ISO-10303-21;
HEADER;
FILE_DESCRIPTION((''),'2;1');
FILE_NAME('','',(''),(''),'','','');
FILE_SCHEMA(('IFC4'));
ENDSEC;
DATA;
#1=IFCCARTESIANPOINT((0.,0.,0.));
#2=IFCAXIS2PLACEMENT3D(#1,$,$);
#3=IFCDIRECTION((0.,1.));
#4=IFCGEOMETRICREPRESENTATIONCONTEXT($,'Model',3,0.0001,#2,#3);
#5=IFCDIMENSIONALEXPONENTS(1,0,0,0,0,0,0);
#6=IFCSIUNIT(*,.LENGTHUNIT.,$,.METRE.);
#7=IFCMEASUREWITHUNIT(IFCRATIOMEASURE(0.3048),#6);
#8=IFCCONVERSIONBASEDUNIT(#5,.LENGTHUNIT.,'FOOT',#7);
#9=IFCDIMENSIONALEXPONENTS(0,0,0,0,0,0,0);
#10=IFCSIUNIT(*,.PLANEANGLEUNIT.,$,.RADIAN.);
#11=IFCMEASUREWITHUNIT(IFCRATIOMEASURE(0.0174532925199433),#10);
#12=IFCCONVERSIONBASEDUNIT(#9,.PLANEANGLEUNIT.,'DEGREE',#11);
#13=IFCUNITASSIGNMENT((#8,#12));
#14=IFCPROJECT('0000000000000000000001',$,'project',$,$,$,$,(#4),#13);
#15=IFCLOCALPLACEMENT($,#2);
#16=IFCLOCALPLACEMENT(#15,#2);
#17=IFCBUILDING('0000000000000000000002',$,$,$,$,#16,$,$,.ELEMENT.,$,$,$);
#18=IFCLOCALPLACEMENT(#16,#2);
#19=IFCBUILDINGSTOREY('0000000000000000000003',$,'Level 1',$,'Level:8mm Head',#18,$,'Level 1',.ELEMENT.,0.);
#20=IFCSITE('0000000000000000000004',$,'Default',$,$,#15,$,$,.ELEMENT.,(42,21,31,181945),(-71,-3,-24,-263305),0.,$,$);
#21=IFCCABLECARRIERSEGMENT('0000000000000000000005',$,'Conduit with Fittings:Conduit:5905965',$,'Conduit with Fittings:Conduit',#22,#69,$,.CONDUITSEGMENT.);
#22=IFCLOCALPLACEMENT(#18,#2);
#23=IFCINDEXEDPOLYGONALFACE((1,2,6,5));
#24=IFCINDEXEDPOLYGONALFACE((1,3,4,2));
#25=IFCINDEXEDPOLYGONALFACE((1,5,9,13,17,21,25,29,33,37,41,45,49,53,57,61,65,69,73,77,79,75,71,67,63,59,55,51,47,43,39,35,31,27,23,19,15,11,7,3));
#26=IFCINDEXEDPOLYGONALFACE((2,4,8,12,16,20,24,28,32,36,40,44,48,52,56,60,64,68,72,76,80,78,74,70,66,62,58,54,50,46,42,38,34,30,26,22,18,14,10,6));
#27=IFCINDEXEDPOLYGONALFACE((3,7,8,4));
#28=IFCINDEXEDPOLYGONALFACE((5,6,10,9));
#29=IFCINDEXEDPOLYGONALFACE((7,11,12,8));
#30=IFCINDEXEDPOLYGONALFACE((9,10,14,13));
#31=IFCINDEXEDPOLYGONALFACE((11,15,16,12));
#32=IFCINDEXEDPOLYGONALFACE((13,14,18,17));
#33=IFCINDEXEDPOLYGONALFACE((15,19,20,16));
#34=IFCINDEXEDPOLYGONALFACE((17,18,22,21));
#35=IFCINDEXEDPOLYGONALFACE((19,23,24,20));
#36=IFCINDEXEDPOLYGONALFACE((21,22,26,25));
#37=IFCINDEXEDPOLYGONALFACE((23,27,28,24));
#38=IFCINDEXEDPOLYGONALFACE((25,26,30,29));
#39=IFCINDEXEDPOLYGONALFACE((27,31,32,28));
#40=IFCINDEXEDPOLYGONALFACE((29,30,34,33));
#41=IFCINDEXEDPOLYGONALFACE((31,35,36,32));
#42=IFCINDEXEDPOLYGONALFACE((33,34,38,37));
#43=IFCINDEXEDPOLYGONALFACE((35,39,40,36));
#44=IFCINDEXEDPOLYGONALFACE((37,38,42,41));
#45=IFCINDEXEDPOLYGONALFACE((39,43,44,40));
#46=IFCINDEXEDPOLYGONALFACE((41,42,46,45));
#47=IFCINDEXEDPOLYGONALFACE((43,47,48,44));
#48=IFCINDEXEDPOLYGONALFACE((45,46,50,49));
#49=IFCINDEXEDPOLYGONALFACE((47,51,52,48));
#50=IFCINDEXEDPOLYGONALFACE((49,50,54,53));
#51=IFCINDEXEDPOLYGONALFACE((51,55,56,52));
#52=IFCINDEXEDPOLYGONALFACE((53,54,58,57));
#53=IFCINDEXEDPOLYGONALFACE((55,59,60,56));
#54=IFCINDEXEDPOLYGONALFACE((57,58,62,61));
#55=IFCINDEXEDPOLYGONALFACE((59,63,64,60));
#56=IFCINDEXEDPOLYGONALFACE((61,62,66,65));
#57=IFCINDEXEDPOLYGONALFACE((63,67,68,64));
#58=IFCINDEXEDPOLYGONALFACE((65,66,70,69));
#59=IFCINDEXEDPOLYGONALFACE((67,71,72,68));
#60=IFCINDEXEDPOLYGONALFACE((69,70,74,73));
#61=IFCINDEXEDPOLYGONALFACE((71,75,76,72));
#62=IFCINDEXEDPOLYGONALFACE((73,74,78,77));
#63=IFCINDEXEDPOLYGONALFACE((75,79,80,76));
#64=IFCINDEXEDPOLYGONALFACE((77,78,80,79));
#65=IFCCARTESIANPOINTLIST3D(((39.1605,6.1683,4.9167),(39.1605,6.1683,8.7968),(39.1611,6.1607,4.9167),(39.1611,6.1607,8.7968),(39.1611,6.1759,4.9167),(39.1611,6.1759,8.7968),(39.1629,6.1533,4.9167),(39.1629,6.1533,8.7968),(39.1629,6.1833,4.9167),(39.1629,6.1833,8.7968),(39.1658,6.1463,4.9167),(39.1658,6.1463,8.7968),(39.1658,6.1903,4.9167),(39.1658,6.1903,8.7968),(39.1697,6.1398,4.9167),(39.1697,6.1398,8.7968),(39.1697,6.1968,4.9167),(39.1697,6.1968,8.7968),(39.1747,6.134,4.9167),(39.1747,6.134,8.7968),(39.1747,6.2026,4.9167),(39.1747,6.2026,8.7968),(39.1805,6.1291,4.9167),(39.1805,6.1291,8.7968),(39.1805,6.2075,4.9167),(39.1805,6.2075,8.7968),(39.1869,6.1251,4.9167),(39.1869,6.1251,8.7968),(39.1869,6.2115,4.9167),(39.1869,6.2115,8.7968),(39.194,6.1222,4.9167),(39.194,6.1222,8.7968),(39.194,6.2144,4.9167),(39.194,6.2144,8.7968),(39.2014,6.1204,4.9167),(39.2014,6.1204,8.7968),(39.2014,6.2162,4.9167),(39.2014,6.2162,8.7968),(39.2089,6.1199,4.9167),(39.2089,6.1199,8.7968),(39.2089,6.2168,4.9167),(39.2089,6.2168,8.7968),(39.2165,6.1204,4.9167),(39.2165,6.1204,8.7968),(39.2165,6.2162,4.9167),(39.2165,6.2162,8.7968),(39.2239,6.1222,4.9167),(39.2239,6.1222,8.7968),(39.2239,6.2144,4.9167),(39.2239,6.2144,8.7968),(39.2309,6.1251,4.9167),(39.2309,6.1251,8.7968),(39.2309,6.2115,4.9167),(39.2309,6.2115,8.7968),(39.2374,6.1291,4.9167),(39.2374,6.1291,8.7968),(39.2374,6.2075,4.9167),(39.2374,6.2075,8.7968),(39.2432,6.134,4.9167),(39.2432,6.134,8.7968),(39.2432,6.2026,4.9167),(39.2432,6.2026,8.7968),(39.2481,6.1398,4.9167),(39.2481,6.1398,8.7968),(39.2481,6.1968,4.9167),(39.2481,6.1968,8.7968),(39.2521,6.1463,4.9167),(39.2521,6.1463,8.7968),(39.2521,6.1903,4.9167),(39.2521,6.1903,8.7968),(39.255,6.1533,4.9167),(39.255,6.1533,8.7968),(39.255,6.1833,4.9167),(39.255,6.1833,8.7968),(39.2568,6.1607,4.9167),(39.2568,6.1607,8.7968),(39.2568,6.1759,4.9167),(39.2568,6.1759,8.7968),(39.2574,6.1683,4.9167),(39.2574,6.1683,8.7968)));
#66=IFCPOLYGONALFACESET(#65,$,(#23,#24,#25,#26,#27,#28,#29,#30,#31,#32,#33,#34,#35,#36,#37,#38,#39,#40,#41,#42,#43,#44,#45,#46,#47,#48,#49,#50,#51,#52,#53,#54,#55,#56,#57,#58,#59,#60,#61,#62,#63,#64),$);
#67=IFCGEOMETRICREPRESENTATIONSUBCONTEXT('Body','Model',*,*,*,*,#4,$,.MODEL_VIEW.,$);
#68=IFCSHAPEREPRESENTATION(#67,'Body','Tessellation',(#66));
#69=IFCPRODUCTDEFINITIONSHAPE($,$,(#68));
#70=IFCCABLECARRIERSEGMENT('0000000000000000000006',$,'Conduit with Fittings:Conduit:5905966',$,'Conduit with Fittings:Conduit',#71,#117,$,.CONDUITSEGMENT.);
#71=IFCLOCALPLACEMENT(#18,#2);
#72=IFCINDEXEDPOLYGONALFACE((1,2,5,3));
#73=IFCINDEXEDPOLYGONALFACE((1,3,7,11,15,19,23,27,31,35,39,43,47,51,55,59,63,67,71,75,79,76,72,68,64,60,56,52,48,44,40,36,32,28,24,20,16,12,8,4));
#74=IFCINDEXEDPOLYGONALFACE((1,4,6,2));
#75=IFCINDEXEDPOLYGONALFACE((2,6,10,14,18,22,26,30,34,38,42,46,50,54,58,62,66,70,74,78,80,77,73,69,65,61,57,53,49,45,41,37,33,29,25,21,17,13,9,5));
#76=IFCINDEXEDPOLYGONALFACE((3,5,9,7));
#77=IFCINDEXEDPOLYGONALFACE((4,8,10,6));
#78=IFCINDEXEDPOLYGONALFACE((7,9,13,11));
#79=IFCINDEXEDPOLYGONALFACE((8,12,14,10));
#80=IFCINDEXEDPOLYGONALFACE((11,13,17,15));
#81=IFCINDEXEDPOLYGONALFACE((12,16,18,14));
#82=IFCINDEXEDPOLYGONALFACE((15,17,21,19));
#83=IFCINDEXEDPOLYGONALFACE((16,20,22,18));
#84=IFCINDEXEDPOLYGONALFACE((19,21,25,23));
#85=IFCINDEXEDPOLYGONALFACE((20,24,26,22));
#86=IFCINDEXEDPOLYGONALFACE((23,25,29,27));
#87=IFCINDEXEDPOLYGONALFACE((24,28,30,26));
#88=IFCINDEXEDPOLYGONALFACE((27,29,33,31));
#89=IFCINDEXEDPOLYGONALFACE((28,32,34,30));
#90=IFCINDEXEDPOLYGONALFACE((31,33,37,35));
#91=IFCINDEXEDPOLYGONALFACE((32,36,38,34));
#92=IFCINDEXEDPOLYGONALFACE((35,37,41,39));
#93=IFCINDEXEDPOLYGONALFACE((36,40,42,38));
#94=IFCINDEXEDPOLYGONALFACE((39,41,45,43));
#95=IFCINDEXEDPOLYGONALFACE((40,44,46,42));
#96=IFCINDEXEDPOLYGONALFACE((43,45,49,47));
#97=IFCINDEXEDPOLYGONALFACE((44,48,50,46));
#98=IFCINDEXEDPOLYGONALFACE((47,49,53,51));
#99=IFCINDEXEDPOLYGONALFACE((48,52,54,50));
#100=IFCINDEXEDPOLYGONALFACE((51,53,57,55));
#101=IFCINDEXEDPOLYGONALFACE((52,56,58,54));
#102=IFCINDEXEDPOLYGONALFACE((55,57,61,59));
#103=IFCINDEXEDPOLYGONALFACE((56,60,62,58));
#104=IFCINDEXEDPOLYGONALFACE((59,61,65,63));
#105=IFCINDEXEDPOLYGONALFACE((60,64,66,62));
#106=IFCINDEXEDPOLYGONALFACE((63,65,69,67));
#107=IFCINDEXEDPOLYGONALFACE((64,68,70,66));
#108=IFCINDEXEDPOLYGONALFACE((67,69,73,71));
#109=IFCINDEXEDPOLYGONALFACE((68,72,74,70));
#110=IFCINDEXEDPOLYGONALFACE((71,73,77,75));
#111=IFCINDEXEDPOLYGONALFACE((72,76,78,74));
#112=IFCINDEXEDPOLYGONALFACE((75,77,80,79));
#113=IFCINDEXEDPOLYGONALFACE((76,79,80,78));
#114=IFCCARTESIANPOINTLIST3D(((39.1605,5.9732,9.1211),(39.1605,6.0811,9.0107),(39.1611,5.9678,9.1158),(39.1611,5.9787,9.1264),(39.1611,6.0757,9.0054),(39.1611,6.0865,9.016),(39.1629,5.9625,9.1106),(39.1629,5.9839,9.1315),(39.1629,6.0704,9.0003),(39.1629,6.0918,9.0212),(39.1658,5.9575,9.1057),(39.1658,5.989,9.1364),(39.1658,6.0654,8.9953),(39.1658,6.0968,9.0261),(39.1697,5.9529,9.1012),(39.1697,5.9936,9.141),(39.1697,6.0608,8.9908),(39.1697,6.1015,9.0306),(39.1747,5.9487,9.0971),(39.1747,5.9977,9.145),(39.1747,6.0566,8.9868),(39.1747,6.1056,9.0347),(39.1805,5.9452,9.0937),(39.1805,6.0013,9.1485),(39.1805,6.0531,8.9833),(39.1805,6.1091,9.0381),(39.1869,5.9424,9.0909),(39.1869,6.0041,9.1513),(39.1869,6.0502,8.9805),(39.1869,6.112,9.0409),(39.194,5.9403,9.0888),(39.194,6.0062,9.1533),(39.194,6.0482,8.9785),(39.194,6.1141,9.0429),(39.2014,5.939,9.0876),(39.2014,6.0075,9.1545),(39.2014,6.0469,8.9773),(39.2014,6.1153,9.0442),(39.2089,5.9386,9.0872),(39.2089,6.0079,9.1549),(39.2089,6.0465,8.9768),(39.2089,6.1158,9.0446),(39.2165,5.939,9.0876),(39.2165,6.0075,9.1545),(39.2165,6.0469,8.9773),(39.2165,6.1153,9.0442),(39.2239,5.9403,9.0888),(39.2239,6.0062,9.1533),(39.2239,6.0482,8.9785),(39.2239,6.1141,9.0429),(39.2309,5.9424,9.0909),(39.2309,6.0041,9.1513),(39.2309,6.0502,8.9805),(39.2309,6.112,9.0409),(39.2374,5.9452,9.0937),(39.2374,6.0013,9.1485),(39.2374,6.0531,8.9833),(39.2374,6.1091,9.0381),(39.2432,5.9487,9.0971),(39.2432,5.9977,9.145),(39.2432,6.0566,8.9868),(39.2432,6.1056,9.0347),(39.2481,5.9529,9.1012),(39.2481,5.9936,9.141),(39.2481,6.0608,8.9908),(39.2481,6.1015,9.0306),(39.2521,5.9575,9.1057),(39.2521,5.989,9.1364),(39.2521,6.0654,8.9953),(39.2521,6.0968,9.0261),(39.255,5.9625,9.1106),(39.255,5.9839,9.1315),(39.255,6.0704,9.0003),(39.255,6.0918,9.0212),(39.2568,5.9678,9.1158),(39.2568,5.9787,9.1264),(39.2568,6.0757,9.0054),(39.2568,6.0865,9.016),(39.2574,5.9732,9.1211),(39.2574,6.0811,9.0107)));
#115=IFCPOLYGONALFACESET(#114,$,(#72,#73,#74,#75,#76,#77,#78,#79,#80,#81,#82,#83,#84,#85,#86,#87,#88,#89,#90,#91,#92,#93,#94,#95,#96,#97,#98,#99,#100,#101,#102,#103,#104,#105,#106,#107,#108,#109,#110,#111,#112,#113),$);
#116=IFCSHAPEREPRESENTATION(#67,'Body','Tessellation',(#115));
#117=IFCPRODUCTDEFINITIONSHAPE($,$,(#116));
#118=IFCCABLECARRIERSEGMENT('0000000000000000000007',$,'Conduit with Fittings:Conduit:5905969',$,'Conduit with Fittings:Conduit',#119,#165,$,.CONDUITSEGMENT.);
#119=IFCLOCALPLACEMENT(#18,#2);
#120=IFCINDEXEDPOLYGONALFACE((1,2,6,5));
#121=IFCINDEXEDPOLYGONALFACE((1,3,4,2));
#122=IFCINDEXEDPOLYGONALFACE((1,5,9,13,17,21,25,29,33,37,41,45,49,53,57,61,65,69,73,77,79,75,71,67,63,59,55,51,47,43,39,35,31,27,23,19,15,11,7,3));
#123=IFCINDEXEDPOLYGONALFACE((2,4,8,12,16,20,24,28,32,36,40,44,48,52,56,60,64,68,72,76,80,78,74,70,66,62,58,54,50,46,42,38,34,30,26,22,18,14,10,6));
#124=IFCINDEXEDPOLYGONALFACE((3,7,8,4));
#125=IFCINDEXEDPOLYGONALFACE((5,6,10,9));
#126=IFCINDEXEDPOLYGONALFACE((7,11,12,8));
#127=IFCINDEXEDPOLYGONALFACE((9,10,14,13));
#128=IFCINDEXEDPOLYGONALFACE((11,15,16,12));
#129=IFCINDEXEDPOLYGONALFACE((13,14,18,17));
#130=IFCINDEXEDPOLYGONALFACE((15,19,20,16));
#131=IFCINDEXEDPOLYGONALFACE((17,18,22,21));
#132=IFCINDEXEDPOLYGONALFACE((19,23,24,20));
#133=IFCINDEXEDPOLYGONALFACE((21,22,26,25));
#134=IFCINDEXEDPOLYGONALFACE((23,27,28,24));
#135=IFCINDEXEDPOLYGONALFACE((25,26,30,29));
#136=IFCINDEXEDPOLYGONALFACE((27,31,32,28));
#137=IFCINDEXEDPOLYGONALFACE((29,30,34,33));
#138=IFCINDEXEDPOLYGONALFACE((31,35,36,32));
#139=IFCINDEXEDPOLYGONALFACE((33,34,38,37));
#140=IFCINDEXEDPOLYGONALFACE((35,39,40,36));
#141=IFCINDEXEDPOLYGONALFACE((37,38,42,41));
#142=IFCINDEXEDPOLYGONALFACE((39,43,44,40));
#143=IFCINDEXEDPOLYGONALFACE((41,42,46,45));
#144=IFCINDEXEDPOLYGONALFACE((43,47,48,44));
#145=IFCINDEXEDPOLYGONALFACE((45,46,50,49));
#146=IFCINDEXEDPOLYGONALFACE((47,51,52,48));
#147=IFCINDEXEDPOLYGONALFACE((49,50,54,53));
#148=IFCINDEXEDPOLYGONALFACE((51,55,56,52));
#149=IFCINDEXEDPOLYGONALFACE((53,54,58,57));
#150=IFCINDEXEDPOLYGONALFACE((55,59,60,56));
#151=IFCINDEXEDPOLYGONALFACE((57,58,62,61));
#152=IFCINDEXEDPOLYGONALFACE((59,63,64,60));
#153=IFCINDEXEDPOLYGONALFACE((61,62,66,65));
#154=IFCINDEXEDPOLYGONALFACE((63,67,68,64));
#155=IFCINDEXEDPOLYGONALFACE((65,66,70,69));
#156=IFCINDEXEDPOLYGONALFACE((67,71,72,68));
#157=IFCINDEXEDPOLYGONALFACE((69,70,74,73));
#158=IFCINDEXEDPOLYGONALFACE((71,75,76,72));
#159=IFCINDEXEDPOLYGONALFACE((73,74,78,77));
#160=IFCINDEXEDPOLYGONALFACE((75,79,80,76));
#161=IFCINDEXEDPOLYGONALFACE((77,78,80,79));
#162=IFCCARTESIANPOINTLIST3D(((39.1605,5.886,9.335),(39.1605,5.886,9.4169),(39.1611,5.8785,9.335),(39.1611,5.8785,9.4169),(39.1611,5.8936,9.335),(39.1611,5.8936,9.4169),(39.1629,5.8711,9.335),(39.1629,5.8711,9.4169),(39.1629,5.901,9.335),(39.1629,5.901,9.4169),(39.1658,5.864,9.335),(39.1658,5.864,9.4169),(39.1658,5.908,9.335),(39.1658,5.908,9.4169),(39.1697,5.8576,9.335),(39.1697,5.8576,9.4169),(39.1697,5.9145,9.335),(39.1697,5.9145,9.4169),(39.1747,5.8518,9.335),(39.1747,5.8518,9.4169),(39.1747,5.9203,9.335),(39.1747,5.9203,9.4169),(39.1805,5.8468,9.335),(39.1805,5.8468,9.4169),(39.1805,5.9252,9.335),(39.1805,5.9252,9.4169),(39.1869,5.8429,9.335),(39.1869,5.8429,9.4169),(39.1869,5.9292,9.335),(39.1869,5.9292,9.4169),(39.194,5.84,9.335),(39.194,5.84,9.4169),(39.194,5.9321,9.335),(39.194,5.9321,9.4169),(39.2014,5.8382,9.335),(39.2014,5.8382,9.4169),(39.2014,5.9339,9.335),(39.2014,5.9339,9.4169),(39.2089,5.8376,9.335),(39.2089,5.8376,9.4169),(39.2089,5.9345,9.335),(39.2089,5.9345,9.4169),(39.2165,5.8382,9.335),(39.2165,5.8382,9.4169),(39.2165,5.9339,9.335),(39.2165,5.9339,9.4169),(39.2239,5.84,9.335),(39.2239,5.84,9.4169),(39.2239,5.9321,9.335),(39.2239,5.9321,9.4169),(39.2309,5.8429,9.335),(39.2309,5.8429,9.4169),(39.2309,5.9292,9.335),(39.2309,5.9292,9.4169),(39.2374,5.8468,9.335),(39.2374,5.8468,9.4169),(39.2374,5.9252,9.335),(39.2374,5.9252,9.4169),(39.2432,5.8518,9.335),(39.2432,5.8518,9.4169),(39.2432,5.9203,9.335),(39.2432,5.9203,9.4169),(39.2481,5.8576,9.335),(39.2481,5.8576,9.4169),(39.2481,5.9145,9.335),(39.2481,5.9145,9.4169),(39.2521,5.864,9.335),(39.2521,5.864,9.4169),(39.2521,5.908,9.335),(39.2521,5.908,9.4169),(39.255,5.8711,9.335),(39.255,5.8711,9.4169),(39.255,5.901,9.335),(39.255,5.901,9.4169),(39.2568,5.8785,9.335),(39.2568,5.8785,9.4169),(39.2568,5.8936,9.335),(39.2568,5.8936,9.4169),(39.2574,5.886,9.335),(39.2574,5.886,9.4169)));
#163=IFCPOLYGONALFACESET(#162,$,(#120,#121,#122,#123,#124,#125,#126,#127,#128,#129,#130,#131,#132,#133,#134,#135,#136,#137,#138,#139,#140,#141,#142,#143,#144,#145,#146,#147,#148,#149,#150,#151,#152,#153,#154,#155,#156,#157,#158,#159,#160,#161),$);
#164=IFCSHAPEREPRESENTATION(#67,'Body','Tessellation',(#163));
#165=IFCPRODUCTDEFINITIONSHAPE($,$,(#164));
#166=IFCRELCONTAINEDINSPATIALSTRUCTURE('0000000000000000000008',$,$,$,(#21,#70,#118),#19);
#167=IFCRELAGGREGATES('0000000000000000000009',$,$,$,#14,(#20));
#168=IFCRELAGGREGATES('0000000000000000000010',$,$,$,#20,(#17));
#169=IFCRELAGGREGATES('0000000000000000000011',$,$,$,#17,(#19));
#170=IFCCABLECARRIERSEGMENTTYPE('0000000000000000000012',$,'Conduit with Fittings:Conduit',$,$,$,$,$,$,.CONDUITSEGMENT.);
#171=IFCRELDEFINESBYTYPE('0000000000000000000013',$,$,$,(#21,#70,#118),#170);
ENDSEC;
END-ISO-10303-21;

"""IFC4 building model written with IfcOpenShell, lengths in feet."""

from ifc_helpers import new_model, entity, si_unit, converted_unit, direction, frame, origin, place, context, subcontext, project, spatial, indexed_curve, outline, extrude, type_object, element, save


model = new_model("IFC4")

# Units and contexts
model_context = context("Model", 3, precision=0.0001, world=origin(), true_north=direction((0.0, 1.0)))
body_context = subcontext(model_context, "Body", "Model", "MODEL_VIEW")
ifc_project = project(units=[converted_unit("LENGTHUNIT", "FOOT", entity("IfcRatioMeasure", 0.3048), si_unit("LENGTHUNIT", "METRE"), dimensions=[1, 0, 0, 0, 0, 0, 0]), converted_unit("PLANEANGLEUNIT", "DEGREE", entity("IfcRatioMeasure", 0.0174532925199433), si_unit("PLANEANGLEUNIT", "RADIAN"), dimensions=[0, 0, 0, 0, 0, 0, 0])], contexts=[model_context])

# Site, building, storey
site_placement = place(None, origin())
site = spatial("IfcSite", under=ifc_project, at=site_placement, Name="Default", CompositionType="ELEMENT", RefLatitude=(42, 21, 31, 181945), RefLongitude=(-71, -3, -24, -263305), RefElevation=0.0)
building_placement = place(site_placement, origin())
building = spatial("IfcBuilding", under=site, at=building_placement, CompositionType="ELEMENT")
storey_placement = place(building_placement, origin())
storey = spatial("IfcBuildingStorey", under=building, at=storey_placement, Name="Level 1", ObjectType="Level:8mm Head", LongName="Level 1", CompositionType="ELEMENT", Elevation=0.0)

# Cable carrier segments
cable_carrier_segment_type_1 = type_object("IfcCableCarrierSegmentType", Name="Conduit with Fittings:Conduit", PredefinedType="CONDUITSEGMENT")
cable_carrier_segment_1_placement = place(storey_placement, origin())
element("IfcCableCarrierSegment", 1, at=cable_carrier_segment_1_placement, inside=storey, type_object=cable_carrier_segment_type_1, Name="Conduit with Fittings:Conduit:5905965", ObjectType="Conduit with Fittings:Conduit", PredefinedType="CONDUITSEGMENT", context=body_context, shape_type="SweptSolid", body=[
    extrude(outline(indexed_curve([(0.0485, 0.0), (0.0479, 0.0076), (0.0461, 0.015), (0.0432, 0.022), (0.0392, 0.0285), (0.0343, 0.0343), (0.0285, 0.0392), (0.022, 0.0432), (0.015, 0.0461), (0.0076, 0.0479), (0.0, 0.0485), (-0.0076, 0.0479), (-0.015, 0.0461), (-0.022, 0.0432), (-0.0285, 0.0392), (-0.0343, 0.0343), (-0.0392, 0.0285), (-0.0432, 0.022), (-0.0461, 0.015), (-0.0479, 0.0076), (-0.0485, 0.0), (-0.0479, -0.0076), (-0.0461, -0.015), (-0.0432, -0.022), (-0.0392, -0.0285), (-0.0343, -0.0343), (-0.0285, -0.0392), (-0.022, -0.0432), (-0.015, -0.0461), (-0.0076, -0.0479), (0.0, -0.0485), (0.0076, -0.0479), (0.015, -0.0461), (0.022, -0.0432), (0.0285, -0.0392), (0.0343, -0.0343), (0.0392, -0.0285), (0.0432, -0.022), (0.0461, -0.015), (0.0479, -0.0076), (0.0485, 0.0)], self_intersect=False)), frame((39.2089, 6.1683, 4.9167), z_axis=(0.0, 0.0, 1.0), x_axis=(-1.0, 0.0, 0.0)), (0.0, 0.0, 1.0), 3.8801),
])
cable_carrier_segment_2_placement = place(storey_placement, origin())
element("IfcCableCarrierSegment", 2, at=cable_carrier_segment_2_placement, inside=storey, type_object=cable_carrier_segment_type_1, Name="Conduit with Fittings:Conduit:5905966", ObjectType="Conduit with Fittings:Conduit", PredefinedType="CONDUITSEGMENT", context=body_context, shape_type="SweptSolid", body=[
    extrude(outline(indexed_curve([(0.0485, 0.0), (0.0479, 0.0076), (0.0461, 0.015), (0.0432, 0.022), (0.0392, 0.0285), (0.0343, 0.0343), (0.0285, 0.0392), (0.022, 0.0432), (0.015, 0.0461), (0.0076, 0.0479), (0.0, 0.0485), (-0.0076, 0.0479), (-0.015, 0.0461), (-0.022, 0.0432), (-0.0285, 0.0392), (-0.0343, 0.0343), (-0.0392, 0.0285), (-0.0432, 0.022), (-0.0461, 0.015), (-0.0479, 0.0076), (-0.0485, 0.0), (-0.0479, -0.0076), (-0.0461, -0.015), (-0.0432, -0.022), (-0.0392, -0.0285), (-0.0343, -0.0343), (-0.0285, -0.0392), (-0.022, -0.0432), (-0.015, -0.0461), (-0.0076, -0.0479), (0.0, -0.0485), (0.0076, -0.0479), (0.015, -0.0461), (0.022, -0.0432), (0.0285, -0.0392), (0.0343, -0.0343), (0.0392, -0.0285), (0.0432, -0.022), (0.0461, -0.015), (0.0479, -0.0076), (0.0485, 0.0)], self_intersect=False)), frame((39.2089, 5.9732, 9.1211), z_axis=(0.0, 0.699077, -0.715046), x_axis=(-1.0, 0.0, 0.0)), (0.0, 0.0, 1.0), 0.1543),
])
cable_carrier_segment_3_placement = place(storey_placement, origin())
element("IfcCableCarrierSegment", 3, at=cable_carrier_segment_3_placement, inside=storey, type_object=cable_carrier_segment_type_1, Name="Conduit with Fittings:Conduit:5905969", ObjectType="Conduit with Fittings:Conduit", PredefinedType="CONDUITSEGMENT", context=body_context, shape_type="SweptSolid", body=[
    extrude(outline(indexed_curve([(0.0485, 0.0), (0.0479, 0.0076), (0.0461, 0.015), (0.0432, 0.022), (0.0392, 0.0285), (0.0343, 0.0343), (0.0285, 0.0392), (0.022, 0.0432), (0.015, 0.0461), (0.0076, 0.0479), (0.0, 0.0485), (-0.0076, 0.0479), (-0.015, 0.0461), (-0.022, 0.0432), (-0.0285, 0.0392), (-0.0343, 0.0343), (-0.0392, 0.0285), (-0.0432, 0.022), (-0.0461, 0.015), (-0.0479, 0.0076), (-0.0485, 0.0), (-0.0479, -0.0076), (-0.0461, -0.015), (-0.0432, -0.022), (-0.0392, -0.0285), (-0.0343, -0.0343), (-0.0285, -0.0392), (-0.022, -0.0432), (-0.015, -0.0461), (-0.0076, -0.0479), (0.0, -0.0485), (0.0076, -0.0479), (0.015, -0.0461), (0.022, -0.0432), (0.0285, -0.0392), (0.0343, -0.0343), (0.0392, -0.0285), (0.0432, -0.022), (0.0461, -0.015), (0.0479, -0.0076), (0.0485, 0.0)], self_intersect=False)), frame((39.2089, 5.886, 9.335), z_axis=(0.0, 0.0, 1.0), x_axis=(-1.0, 0.0, 0.0)), (0.0, 0.0, 1.0), 0.082),
])

save(model, "model.ifc")
